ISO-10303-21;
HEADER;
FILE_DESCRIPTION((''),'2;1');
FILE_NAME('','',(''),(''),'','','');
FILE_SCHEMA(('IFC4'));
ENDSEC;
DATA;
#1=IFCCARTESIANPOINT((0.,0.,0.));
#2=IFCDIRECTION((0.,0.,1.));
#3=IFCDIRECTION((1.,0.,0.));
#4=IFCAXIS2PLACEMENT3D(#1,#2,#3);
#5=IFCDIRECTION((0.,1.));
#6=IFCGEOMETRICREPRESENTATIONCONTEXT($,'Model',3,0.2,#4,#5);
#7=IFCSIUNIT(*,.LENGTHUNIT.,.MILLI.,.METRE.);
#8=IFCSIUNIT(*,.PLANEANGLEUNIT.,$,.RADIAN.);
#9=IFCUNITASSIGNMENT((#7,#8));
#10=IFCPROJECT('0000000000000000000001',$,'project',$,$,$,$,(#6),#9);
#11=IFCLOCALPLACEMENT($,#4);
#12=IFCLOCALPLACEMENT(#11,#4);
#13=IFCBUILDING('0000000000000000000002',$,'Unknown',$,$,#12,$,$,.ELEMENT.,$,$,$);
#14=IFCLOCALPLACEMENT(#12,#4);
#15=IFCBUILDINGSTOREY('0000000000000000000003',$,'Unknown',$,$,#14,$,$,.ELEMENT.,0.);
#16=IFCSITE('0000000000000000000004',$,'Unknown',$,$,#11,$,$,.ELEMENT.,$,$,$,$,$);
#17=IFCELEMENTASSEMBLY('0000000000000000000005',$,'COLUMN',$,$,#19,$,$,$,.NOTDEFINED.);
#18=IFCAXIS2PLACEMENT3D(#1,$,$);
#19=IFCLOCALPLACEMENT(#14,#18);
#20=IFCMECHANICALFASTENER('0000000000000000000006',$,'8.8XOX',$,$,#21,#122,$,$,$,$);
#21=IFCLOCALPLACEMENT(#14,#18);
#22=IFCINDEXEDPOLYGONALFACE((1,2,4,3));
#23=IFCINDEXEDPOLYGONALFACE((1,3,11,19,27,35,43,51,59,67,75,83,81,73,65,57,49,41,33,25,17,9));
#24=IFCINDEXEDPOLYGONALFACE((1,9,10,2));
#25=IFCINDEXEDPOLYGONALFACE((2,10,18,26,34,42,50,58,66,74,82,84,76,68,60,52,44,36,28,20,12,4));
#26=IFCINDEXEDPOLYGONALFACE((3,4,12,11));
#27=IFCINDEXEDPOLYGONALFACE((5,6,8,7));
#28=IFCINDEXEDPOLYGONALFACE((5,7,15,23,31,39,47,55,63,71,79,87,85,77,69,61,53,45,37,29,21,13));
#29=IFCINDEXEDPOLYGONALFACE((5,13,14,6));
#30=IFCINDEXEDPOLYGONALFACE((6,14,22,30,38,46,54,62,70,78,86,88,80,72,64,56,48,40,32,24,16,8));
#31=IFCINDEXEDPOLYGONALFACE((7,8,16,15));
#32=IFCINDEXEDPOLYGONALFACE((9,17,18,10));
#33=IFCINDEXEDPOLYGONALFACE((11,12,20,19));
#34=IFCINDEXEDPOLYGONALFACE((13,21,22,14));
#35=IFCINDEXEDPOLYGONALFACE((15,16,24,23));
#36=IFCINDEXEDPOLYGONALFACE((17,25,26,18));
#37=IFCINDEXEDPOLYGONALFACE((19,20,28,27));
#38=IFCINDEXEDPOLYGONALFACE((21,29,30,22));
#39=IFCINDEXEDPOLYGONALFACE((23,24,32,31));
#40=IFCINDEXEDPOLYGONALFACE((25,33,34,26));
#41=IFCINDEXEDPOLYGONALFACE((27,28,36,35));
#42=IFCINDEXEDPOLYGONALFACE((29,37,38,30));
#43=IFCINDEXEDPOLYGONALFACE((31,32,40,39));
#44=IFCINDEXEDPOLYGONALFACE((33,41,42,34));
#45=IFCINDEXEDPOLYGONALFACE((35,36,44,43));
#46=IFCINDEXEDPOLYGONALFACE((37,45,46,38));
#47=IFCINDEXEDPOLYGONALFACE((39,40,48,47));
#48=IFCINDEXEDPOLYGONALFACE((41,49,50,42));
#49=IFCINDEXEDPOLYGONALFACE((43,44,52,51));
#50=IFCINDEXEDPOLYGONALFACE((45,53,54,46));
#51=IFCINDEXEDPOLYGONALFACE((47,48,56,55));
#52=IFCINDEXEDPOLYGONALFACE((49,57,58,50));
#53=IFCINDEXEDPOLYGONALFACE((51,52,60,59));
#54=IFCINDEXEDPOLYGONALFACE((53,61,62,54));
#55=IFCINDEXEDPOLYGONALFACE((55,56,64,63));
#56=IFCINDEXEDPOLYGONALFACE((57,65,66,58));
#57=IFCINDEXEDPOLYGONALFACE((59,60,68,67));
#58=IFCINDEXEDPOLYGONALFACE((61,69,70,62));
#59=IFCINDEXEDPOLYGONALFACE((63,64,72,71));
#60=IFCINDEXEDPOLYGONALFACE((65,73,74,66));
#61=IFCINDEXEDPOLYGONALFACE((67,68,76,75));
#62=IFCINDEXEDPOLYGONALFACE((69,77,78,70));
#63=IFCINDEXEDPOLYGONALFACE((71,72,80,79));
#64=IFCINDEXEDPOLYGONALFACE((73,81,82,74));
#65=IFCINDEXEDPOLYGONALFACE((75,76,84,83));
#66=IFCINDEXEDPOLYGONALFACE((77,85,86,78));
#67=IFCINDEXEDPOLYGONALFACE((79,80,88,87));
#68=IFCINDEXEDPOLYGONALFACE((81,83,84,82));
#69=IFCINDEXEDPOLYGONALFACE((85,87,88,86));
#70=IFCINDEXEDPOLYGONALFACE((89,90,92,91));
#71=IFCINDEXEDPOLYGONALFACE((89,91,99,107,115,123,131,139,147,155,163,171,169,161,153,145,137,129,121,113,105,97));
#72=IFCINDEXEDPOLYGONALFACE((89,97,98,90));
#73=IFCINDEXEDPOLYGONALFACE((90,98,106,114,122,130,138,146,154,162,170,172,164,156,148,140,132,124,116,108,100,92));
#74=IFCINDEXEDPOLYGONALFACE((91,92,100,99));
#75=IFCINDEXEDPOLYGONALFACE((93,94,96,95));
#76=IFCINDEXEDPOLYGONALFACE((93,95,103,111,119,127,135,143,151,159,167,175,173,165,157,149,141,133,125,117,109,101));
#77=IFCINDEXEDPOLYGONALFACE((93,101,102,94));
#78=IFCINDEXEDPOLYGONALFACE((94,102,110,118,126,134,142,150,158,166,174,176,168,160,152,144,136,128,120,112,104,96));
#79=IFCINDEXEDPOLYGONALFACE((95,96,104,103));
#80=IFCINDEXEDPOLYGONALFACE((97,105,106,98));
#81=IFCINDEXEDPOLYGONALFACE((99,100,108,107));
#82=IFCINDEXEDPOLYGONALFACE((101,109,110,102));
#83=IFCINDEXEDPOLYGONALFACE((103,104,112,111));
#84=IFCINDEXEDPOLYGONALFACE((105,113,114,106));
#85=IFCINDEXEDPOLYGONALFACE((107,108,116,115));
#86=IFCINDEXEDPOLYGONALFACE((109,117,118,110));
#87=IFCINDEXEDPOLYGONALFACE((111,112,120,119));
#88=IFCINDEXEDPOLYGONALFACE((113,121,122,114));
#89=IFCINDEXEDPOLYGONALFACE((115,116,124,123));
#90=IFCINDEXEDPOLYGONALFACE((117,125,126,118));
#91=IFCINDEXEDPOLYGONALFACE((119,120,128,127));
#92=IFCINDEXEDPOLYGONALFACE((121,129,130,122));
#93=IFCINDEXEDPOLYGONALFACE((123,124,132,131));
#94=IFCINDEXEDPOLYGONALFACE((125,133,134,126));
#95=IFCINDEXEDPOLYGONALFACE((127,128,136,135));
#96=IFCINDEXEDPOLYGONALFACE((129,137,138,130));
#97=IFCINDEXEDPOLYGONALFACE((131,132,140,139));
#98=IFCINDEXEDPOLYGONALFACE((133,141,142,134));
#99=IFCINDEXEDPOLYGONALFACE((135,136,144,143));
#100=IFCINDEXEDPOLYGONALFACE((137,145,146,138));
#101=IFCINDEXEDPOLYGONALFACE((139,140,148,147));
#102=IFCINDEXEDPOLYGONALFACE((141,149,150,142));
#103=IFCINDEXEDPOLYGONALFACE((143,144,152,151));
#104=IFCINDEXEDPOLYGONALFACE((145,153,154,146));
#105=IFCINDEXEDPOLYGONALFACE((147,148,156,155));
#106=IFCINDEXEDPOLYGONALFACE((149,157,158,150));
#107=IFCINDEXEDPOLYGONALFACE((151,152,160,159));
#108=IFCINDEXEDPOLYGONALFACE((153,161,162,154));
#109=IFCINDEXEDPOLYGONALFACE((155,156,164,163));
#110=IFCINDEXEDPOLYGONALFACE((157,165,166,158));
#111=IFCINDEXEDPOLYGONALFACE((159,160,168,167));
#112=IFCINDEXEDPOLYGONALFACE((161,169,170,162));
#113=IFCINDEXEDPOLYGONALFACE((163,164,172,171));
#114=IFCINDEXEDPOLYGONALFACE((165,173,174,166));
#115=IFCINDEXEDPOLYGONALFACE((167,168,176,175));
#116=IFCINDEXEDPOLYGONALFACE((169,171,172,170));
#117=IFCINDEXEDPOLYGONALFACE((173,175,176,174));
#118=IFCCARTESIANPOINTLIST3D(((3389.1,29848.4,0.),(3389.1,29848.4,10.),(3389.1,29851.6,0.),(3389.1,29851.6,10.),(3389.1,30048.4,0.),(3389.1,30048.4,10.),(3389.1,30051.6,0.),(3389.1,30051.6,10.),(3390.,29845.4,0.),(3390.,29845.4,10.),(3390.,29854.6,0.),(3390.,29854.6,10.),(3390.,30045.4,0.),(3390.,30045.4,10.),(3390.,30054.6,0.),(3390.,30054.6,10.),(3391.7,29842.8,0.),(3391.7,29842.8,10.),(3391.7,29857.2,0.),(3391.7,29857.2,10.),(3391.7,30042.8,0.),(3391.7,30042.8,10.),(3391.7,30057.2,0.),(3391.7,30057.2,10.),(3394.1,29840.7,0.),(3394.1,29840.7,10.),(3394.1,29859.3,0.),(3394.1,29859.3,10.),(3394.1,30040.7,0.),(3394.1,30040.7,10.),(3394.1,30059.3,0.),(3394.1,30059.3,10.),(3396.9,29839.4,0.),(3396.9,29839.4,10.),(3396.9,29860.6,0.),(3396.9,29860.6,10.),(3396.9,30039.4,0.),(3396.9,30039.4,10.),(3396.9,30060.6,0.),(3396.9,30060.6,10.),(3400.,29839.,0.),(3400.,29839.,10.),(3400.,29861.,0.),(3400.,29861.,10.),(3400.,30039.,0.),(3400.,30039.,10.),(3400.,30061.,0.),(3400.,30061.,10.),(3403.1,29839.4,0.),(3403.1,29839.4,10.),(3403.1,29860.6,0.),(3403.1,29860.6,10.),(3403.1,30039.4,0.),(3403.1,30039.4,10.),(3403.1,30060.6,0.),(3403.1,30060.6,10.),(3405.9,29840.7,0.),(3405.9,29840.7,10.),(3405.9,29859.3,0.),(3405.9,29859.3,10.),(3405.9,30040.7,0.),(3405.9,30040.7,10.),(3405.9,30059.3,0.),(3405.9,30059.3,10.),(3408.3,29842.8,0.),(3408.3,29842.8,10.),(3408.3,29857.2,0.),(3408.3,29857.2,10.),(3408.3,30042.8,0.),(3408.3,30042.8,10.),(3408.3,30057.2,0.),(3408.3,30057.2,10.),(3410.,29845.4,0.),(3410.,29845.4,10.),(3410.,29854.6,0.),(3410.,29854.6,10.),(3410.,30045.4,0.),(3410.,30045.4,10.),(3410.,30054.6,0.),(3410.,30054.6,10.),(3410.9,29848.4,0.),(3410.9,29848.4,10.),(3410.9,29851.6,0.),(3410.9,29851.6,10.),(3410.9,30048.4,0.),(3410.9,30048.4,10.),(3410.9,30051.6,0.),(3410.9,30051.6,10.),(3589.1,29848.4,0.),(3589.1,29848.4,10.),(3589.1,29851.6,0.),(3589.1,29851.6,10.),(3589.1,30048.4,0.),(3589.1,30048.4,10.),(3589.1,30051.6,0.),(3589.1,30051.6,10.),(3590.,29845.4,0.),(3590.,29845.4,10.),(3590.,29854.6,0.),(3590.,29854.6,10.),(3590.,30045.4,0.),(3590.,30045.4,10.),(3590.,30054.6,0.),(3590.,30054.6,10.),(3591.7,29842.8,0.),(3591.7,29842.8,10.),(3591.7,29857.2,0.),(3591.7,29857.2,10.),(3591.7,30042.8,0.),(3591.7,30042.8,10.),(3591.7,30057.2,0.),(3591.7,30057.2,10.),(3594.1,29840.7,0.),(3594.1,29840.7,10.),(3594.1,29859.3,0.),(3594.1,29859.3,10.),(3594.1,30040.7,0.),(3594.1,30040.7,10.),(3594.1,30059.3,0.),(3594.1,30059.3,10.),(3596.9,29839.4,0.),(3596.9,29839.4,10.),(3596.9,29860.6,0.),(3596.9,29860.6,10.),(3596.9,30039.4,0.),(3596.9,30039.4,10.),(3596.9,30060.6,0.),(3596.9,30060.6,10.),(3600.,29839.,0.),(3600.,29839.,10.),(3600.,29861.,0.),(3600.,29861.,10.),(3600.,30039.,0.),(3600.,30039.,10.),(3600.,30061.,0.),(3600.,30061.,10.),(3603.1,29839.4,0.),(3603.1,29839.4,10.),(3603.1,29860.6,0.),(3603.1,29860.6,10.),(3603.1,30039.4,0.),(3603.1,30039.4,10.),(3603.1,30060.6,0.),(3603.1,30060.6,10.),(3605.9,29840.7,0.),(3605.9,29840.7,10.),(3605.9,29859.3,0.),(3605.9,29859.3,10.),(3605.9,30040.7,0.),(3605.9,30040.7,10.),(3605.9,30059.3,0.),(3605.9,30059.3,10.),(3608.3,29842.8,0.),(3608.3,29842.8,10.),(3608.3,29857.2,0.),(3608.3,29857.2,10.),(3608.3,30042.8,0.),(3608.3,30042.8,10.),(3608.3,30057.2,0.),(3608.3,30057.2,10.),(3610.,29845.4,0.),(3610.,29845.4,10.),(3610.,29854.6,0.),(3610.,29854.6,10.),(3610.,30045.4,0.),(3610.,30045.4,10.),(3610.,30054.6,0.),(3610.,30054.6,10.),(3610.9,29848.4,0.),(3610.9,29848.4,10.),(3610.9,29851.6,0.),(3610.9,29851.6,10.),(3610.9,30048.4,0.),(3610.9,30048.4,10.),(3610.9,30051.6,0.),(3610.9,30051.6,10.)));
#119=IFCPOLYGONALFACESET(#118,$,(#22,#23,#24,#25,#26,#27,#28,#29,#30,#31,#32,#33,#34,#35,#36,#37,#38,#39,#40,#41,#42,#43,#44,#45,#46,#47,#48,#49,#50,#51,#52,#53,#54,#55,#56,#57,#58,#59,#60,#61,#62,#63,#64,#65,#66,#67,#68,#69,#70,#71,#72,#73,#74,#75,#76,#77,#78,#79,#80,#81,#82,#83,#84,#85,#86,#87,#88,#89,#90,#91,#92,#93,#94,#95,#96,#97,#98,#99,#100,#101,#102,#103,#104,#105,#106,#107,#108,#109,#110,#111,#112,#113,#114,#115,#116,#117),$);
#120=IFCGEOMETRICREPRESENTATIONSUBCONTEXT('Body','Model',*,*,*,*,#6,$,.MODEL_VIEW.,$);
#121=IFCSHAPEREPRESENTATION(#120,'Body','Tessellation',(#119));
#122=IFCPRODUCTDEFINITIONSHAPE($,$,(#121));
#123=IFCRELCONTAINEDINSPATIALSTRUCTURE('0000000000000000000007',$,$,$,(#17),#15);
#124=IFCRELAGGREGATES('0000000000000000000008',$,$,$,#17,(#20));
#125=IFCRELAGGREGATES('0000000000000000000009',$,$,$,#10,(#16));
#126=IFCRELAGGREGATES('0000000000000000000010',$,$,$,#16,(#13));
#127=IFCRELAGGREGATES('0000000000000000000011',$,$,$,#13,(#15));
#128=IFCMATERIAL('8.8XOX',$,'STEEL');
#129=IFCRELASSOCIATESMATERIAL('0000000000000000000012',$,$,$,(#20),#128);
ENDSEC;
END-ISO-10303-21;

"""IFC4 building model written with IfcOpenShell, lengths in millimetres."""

from ifc_helpers import new_model, si_unit, direction, frame, origin_with_axes, place, context, subcontext, project, spatial, arc, indexed_curve, outline, extrude, source, transform, mapped, material, element, aggregate, save


model = new_model("IFC4")

# Units and contexts
model_context = context("Model", 3, precision=0.2, world=origin_with_axes(), true_north=direction((0.0, 1.0)))
body_context = subcontext(model_context, "Body", "Model", "MODEL_VIEW")
ifc_project = project(units=[si_unit("LENGTHUNIT", "METRE", prefix="MILLI"), si_unit("PLANEANGLEUNIT", "RADIAN")], contexts=[model_context])

# Site, building, storey
site_placement = place(None, origin_with_axes())
site = spatial("IfcSite", under=ifc_project, at=site_placement, Name="Unknown", CompositionType="ELEMENT")
building_placement = place(site_placement, origin_with_axes())
building = spatial("IfcBuilding", under=site, at=building_placement, Name="Unknown", CompositionType="ELEMENT")
storey_placement = place(building_placement, origin_with_axes())
storey = spatial("IfcBuildingStorey", under=building, at=storey_placement, Name="Unknown", CompositionType="ELEMENT", Elevation=0.0)

# Element assembly
assembly_1_placement = place(storey_placement, frame((3500.0, 29950.0, 0.0), z_axis=(0.0, 1.0, 0.0), x_axis=(0.0, 0.0, 1.0)))
assembly_1 = element("IfcElementAssembly", 1, at=assembly_1_placement, inside=storey, Name="COLUMN", PredefinedType="NOTDEFINED")

# Shared definitions
ifc_material_1 = material(Name="8.8XOX", Category="STEEL")
shared_shape_1 = source(origin_with_axes(), body_context, "Body", "SweptSolid", [
    extrude(outline(indexed_curve([(11.0, 0.0), (0.0, 11.0), (-11.0, 0.0), (0.0, -11.0)], segments=[arc(1, 2, 3), arc(3, 4, 1)])), frame((0.0, 0.0, 0.0), z_axis=(0.0, 0.0, -1.0), x_axis=(0.0, 1.0, 0.0)), (0.0, 0.0, 1.0), 10.0),
])

# Mechanical fastener
mechanical_fastener_1_placement = place(assembly_1_placement, frame((10.0, 50.0, 0.0), z_axis=(1.0, 0.0, 0.0), x_axis=(0.0, -1.0, 0.0)))
mechanical_fastener_1 = element("IfcMechanicalFastener", 2, at=mechanical_fastener_1_placement, material=ifc_material_1, Name="8.8XOX", context=body_context, shape_type="MappedRepresentation", body=[
    mapped(shared_shape_1, transform((-50.0, 100.0, 0.0))),
    mapped(shared_shape_1, transform((-50.0, -100.0, 0.0))),
    mapped(shared_shape_1, transform((150.0, 100.0, 0.0))),
    mapped(shared_shape_1, transform((150.0, -100.0, 0.0))),
])
aggregate(assembly_1, [mechanical_fastener_1])

save(model, "model.ifc")
